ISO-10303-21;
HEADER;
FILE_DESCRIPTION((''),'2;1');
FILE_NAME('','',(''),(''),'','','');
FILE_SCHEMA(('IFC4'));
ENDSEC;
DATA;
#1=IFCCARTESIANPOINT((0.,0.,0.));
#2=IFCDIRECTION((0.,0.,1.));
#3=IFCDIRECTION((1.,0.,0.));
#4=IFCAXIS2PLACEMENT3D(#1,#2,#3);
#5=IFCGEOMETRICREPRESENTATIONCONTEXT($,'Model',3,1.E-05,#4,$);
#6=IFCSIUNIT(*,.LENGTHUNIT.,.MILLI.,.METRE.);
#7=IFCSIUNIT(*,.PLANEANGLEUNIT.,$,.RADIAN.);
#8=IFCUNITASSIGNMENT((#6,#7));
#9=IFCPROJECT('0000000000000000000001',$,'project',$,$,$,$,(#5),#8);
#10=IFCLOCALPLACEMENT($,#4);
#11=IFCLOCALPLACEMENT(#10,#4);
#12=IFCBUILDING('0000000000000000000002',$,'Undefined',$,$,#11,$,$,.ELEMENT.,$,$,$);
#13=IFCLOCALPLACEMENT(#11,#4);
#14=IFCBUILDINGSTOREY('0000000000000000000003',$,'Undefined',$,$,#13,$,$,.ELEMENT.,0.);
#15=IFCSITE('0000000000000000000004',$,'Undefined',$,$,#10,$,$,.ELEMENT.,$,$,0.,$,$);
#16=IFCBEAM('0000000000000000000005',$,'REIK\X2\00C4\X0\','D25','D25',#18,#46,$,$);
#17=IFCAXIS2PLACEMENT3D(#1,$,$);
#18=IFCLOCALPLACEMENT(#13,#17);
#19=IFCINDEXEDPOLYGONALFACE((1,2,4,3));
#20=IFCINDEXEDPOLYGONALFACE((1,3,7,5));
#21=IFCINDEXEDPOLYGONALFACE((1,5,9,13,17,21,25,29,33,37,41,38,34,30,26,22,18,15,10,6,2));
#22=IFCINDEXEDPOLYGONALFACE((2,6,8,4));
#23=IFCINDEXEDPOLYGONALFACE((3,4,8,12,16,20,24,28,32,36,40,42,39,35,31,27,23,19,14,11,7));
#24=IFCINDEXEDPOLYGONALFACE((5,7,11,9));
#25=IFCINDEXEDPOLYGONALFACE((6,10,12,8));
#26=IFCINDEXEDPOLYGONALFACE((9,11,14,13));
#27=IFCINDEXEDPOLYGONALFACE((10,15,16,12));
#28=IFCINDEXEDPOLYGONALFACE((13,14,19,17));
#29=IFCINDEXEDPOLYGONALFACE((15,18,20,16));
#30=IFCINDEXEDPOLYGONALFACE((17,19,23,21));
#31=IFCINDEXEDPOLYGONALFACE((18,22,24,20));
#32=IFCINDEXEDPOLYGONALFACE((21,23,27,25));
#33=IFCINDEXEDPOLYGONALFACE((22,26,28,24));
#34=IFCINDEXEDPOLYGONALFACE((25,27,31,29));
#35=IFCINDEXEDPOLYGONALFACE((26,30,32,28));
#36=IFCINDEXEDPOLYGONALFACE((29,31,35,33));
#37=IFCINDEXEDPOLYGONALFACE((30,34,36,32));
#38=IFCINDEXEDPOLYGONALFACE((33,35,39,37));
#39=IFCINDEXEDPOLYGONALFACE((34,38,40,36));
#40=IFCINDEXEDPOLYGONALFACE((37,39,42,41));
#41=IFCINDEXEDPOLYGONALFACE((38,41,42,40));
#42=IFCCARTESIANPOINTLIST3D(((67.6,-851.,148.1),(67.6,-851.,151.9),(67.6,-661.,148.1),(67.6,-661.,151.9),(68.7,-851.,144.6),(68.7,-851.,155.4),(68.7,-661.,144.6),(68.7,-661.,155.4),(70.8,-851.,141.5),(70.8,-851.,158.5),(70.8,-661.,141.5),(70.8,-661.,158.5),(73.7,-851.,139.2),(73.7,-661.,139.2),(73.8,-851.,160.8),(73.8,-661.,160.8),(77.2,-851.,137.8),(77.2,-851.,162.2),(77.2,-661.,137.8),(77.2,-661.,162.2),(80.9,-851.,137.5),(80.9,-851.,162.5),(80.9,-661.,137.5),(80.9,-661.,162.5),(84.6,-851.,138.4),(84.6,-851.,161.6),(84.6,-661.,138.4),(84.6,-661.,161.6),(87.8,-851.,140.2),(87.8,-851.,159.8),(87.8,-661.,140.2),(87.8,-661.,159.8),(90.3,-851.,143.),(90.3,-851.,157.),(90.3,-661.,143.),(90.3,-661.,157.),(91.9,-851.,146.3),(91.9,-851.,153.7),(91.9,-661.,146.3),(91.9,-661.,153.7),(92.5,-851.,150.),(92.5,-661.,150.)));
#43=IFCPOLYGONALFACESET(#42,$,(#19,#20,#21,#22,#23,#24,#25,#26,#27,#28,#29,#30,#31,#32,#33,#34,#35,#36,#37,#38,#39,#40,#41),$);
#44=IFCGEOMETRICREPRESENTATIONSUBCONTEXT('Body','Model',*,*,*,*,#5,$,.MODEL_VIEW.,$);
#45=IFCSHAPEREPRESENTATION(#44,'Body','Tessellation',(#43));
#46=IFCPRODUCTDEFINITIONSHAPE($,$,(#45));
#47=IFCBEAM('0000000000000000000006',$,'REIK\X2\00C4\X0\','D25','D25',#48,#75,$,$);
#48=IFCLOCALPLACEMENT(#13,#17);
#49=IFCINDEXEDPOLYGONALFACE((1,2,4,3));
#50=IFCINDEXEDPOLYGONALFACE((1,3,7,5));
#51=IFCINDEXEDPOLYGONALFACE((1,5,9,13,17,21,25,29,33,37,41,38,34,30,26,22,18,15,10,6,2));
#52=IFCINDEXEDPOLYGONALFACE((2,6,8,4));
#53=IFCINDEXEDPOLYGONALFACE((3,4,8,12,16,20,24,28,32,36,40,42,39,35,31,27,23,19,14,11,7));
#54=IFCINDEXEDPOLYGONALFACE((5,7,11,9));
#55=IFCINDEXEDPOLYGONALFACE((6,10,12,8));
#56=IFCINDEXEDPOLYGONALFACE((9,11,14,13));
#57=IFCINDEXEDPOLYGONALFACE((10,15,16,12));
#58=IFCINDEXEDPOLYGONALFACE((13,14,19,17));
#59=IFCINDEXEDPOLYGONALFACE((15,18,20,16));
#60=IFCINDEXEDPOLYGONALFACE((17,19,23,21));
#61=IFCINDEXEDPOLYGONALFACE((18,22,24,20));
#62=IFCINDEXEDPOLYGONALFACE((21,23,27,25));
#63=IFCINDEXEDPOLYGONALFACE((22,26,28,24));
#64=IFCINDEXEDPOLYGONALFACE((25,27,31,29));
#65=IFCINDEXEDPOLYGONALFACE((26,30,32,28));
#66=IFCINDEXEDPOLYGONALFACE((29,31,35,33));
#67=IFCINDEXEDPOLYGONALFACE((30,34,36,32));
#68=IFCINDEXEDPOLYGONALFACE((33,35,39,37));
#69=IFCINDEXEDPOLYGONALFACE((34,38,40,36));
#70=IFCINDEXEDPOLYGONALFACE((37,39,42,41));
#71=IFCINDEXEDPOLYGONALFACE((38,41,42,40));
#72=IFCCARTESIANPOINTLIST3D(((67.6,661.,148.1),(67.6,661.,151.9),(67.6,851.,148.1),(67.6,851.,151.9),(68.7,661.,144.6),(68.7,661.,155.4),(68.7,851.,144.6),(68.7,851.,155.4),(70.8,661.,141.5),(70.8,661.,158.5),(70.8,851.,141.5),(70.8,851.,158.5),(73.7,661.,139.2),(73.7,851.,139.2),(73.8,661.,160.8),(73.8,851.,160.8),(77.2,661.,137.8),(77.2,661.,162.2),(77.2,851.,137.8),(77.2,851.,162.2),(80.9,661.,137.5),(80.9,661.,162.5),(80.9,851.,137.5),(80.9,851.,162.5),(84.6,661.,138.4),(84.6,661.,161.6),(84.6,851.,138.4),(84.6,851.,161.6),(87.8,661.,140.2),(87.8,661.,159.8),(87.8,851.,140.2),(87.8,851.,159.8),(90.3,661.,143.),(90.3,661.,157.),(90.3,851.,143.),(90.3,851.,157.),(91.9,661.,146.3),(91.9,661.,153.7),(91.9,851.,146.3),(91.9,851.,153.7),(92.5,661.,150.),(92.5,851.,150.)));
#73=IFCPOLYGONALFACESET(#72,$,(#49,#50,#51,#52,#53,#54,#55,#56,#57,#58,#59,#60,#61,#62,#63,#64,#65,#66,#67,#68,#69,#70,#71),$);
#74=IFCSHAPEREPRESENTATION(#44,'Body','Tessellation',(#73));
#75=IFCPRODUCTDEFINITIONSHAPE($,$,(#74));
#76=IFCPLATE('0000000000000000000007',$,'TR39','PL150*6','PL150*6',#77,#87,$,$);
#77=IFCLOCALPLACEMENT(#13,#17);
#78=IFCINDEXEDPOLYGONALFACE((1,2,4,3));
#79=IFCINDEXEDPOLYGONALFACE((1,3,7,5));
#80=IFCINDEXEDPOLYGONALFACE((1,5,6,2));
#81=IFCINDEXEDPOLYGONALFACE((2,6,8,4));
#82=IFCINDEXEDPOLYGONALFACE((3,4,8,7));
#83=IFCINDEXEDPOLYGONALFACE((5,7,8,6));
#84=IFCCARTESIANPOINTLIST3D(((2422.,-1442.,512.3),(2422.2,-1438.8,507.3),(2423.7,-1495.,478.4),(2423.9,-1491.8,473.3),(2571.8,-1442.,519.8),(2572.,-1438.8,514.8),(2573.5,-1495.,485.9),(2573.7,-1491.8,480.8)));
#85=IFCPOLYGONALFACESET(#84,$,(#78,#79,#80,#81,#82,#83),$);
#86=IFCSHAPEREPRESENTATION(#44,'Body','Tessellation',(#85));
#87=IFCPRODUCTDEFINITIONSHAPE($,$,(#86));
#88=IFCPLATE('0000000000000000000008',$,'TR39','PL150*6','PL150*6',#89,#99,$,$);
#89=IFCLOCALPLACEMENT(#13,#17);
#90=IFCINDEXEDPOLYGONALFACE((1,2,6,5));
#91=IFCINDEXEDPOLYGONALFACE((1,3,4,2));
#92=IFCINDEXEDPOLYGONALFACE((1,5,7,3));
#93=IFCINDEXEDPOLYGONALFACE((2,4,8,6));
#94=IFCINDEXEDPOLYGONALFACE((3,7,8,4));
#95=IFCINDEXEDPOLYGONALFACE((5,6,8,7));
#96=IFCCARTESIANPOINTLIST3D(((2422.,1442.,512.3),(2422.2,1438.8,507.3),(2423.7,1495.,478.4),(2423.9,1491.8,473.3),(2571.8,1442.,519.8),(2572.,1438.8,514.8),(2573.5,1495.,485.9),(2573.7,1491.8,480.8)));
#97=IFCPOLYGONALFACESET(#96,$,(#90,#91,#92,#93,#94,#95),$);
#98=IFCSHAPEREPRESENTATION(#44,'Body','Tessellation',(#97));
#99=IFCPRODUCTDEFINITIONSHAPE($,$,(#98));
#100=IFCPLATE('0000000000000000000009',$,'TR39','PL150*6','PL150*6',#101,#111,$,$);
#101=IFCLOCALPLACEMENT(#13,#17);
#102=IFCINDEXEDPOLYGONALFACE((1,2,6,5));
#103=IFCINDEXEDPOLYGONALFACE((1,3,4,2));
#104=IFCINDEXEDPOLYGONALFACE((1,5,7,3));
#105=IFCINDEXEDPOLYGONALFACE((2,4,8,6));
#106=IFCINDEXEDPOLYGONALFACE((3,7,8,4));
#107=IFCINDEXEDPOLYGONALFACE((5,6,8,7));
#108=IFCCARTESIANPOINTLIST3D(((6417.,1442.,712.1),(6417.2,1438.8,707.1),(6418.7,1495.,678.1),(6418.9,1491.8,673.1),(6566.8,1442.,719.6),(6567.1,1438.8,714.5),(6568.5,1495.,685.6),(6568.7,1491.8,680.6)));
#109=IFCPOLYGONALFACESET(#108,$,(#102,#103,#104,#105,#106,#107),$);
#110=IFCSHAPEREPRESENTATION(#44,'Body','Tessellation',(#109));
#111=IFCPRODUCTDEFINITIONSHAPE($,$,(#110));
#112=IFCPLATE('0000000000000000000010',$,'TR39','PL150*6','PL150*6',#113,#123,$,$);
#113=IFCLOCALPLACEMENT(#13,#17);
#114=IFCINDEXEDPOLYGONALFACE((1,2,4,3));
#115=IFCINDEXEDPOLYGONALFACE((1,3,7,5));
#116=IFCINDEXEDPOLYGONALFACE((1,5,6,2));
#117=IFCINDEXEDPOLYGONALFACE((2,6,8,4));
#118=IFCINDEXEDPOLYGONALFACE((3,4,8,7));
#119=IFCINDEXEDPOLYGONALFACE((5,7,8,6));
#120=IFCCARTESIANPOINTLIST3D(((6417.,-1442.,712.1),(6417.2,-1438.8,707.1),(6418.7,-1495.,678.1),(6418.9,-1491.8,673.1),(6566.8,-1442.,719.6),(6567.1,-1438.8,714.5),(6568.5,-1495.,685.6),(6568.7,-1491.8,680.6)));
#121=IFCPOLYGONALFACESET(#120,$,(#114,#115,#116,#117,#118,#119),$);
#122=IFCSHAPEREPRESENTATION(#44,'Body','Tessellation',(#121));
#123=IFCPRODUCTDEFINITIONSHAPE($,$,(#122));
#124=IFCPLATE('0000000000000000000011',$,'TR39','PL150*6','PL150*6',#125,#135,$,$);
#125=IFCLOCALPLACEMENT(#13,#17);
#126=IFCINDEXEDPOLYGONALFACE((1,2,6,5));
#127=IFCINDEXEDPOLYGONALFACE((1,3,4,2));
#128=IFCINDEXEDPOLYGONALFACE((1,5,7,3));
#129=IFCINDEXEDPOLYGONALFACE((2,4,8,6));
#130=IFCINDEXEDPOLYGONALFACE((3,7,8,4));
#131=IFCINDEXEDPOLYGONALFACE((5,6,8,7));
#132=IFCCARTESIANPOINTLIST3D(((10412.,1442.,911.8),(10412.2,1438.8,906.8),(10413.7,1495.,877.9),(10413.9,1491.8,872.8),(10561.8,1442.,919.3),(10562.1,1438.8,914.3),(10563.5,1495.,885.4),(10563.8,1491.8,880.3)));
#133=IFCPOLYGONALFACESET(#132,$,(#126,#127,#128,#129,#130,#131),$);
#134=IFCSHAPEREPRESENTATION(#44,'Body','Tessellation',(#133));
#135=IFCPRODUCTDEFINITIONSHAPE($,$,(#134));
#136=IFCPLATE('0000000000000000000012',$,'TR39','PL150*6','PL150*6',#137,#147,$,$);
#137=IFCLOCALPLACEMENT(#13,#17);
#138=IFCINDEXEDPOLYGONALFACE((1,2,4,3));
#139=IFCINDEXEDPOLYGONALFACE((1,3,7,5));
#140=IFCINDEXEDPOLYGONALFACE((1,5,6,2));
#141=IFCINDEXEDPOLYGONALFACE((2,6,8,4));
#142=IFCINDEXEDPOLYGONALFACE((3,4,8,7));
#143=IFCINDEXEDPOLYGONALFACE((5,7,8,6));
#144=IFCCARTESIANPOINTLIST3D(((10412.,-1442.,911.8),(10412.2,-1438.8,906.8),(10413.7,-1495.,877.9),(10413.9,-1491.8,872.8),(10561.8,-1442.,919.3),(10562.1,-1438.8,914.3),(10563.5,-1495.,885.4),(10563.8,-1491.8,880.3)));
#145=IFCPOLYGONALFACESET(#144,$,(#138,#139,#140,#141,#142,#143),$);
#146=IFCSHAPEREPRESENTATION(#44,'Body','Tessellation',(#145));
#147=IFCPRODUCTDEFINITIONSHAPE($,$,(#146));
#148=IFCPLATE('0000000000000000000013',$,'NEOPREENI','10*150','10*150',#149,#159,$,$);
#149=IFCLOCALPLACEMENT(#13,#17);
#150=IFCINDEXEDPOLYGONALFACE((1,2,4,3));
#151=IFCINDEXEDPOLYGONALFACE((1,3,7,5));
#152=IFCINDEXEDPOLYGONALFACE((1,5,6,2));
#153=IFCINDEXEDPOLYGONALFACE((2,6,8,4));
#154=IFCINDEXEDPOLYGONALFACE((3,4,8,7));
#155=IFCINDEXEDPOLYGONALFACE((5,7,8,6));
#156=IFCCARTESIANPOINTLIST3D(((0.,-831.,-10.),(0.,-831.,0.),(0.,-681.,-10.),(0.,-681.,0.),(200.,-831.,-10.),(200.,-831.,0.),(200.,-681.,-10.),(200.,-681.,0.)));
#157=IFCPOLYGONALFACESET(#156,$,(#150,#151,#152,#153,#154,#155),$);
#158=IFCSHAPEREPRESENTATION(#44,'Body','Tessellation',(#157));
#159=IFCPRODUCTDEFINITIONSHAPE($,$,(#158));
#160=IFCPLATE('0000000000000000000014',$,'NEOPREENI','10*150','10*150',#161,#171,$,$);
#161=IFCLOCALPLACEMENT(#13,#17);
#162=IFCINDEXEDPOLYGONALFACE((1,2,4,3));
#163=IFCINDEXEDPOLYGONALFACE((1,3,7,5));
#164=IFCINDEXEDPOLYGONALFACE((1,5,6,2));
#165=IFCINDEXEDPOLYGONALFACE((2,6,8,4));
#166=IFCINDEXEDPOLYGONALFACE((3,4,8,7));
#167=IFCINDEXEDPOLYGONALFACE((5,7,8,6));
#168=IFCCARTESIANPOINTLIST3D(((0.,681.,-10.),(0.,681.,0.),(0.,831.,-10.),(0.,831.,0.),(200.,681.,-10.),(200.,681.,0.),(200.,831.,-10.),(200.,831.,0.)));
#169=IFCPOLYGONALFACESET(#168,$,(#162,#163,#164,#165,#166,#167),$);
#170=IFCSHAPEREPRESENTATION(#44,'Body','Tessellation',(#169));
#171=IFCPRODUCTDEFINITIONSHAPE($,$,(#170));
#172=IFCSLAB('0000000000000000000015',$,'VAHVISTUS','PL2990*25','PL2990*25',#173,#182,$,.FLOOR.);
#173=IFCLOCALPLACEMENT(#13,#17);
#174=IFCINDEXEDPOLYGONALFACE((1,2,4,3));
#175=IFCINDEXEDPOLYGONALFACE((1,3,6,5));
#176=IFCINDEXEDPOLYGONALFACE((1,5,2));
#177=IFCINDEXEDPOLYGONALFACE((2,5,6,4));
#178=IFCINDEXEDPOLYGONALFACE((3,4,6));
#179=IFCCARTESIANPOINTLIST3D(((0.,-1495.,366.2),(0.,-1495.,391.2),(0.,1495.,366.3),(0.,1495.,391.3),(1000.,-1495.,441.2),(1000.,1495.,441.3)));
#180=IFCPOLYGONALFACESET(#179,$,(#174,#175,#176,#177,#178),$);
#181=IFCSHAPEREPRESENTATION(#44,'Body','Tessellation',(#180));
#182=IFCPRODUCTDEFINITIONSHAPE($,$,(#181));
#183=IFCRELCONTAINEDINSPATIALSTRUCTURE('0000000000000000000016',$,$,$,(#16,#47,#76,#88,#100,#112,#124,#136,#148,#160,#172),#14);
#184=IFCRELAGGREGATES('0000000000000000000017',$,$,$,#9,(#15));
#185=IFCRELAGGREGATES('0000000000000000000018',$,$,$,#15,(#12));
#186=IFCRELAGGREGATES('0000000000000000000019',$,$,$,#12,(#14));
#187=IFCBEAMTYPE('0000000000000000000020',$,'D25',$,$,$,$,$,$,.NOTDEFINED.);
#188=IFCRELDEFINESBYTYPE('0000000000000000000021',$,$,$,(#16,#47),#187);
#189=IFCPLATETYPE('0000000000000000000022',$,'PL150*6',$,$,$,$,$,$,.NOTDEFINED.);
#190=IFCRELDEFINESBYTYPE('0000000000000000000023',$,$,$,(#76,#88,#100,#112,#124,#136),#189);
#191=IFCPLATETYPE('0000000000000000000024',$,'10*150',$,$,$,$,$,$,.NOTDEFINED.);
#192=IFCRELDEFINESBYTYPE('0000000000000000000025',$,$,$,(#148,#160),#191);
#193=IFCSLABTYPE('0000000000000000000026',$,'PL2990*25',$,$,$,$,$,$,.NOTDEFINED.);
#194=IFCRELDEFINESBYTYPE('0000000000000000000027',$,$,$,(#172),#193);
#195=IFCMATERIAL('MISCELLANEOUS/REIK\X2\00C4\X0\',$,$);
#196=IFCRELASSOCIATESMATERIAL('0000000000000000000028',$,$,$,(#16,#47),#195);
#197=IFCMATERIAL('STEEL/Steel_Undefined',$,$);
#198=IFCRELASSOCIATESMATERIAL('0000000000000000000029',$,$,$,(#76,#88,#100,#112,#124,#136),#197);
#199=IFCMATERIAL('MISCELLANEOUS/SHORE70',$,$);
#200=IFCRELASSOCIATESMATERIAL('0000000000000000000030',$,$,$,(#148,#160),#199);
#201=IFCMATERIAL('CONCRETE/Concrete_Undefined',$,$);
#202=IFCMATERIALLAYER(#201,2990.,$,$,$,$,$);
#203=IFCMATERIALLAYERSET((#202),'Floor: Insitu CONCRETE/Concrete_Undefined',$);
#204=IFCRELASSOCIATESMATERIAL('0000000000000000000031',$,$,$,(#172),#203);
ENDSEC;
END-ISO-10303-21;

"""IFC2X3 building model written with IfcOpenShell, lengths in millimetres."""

from ifc_helpers import new_model, si_unit, frame, origin_with_axes, origin_2d_with_axis, place, context, subcontext, project, spatial, polyline, circle, outline, extrude, material, layer, layer_set, layer_usage, type_object, element, save


model = new_model("IFC2X3")

# Units and contexts
model_context = context("Model", 3, precision=1e-05, world=origin_with_axes())
body_context = subcontext(model_context, "Body", "Model", "MODEL_VIEW")
ifc_project = project(units=[si_unit("LENGTHUNIT", "METRE", prefix="MILLI"), si_unit("PLANEANGLEUNIT", "RADIAN")], contexts=[model_context])

# Site, building, storey
site_placement = place(None, origin_with_axes())
site = spatial("IfcSite", under=ifc_project, at=site_placement, Name="Undefined", CompositionType="ELEMENT", RefElevation=0.0)
building_placement = place(site_placement, origin_with_axes())
building = spatial("IfcBuilding", under=site, at=building_placement, Name="Undefined", CompositionType="ELEMENT")
storey_placement = place(building_placement, origin_with_axes())
storey = spatial("IfcBuildingStorey", under=building, at=storey_placement, Name="Undefined", CompositionType="ELEMENT", Elevation=0.0)

# Beams
ifc_material_1 = material(Name="MISCELLANEOUS/REIKÄ")
beam_type = type_object("IfcBeamType", Name="D25", PredefinedType="NOTDEFINED")
for number, where, z_axis, x_axis, name in (
    (1, (80.0, -851.0, 150.0), (0.0, 0.0, 1.0), (0.0, 1.0, 0.0), "REIKÄ"),
    (2, (80.0, 661.0, 150.0), (0.0, 0.0, 1.0), (0.0, 1.0, 0.0), "REIKÄ"),
):
    element("IfcBeam", number, at=place(storey_placement, frame(where, z_axis=z_axis, x_axis=x_axis)), inside=storey, type_object=beam_type, material=ifc_material_1, Name=name, Description="D25", ObjectType="D25", context=body_context, shape_type="SweptSolid", body=[
        extrude(circle(Radius=12.5, at=origin_2d_with_axis()), frame((190.0, 0.0, 0.0), z_axis=(-1.0, 0.0, 0.0), x_axis=(0.0, -1.0, 0.0)), (0.0, 0.0, 1.0), 190.0),
    ])

# Plates
ifc_material_2 = material(Name="STEEL/Steel_Undefined")
plate_type_1 = type_object("IfcPlateType", Name="PL150*6", PredefinedType="NOTDEFINED")
for number, where, z_axis, x_axis, name in (
    (3, (2496.9, -1442.0, 516.1), (0.998752, 0.0, 0.049938), (0.026964, -0.841694, -0.539281), "TR39"),
    (4, (2496.9, 1442.0, 516.1), (-0.998752, 0.0, -0.049938), (0.026964, 0.841694, -0.539281), "TR39"),
    (5, (6491.9, 1442.0, 715.8), (-0.998752, 0.0, -0.049938), (0.026964, 0.841694, -0.539281), "TR39"),
    (6, (6491.9, -1442.0, 715.8), (0.998752, 0.0, 0.049938), (0.026964, -0.841694, -0.539281), "TR39"),
    (7, (10486.9, 1442.0, 915.6), (-0.998752, 0.0, -0.049938), (0.026964, 0.841694, -0.539281), "TR39"),
    (8, (10486.9, -1442.0, 915.6), (0.998752, 0.0, 0.049938), (0.026964, -0.841694, -0.539281), "TR39"),
):
    element("IfcPlate", number, at=place(storey_placement, frame(where, z_axis=z_axis, x_axis=x_axis)), inside=storey, type_object=plate_type_1, material=ifc_material_2, Name=name, Description="PL150*6", ObjectType="PL150*6", context=body_context, shape_type="SweptSolid", body=[
        extrude(outline(polyline([(0.0, 0.0), (63.0, 0.0), (63.0, 6.0), (0.0, 6.0), (0.0, 0.0)])), frame((0.0, 0.0, -75.0), z_axis=(0.0, 0.0, 1.0), x_axis=(1.0, 0.0, 0.0)), (0.0, 0.0, 1.0), 150.0),
    ])
ifc_material_3 = material(Name="MISCELLANEOUS/SHORE70")
plate_type_2 = type_object("IfcPlateType", Name="10*150", PredefinedType="NOTDEFINED")
for number, where, z_axis, x_axis, name in (
    (9, (0.0, -831.0, -5.0), (0.0, 0.0, 1.0), (1.0, 0.0, 0.0), "NEOPREENI"),
    (10, (0.0, 681.0, -5.0), (0.0, 0.0, 1.0), (1.0, 0.0, 0.0), "NEOPREENI"),
):
    element("IfcPlate", number, at=place(storey_placement, frame(where, z_axis=z_axis, x_axis=x_axis)), inside=storey, type_object=plate_type_2, material=ifc_material_3, Name=name, Description="10*150", ObjectType="10*150", context=body_context, shape_type="SweptSolid", body=[
        extrude(outline(polyline([(0.0, 0.0), (200.0, 0.0), (200.0, 150.0), (0.0, 150.0), (0.0, 0.0)])), frame((0.0, 0.0, -5.0), z_axis=(0.0, 0.0, 1.0), x_axis=(1.0, 0.0, 0.0)), (0.0, 0.0, 1.0), 10.0),
    ])

# Slab
ifc_material_4 = material(Name="CONCRETE/Concrete_Undefined")
ifc_layer = layer(ifc_material_4, 2990.0)
ifc_layer_set = layer_set([ifc_layer], Name="Floor: Insitu CONCRETE/Concrete_Undefined")
ifc_layer_usage = layer_usage(ifc_layer_set, "AXIS3", "POSITIVE", -1495.0)
slab_type = type_object("IfcSlabType", Name="PL2990*25", PredefinedType="NOTDEFINED")
slab_placement = place(storey_placement, frame((0.0, 0.0, 391.2), z_axis=(0.0, -1.0, 0.0), x_axis=(0.0, 0.0, -1.0)))
element("IfcSlab", 11, at=slab_placement, inside=storey, type_object=slab_type, material=ifc_layer_usage, Name="VAHVISTUS", Description="PL2990*25", ObjectType="PL2990*25", PredefinedType="FLOOR", context=body_context, shape_type="SweptSolid", body=[
    extrude(outline(polyline([(0.0, 0.0), (25.0, 0.0), (-50.0, 1000.0), (0.0, 0.0)])), frame((0.0, 0.0, -1495.0), z_axis=(0.0, 0.0, 1.0), x_axis=(1.0, 0.0, 0.0)), (0.0, 0.0, 1.0), 2990.0),
])

save(model, "model.ifc")
